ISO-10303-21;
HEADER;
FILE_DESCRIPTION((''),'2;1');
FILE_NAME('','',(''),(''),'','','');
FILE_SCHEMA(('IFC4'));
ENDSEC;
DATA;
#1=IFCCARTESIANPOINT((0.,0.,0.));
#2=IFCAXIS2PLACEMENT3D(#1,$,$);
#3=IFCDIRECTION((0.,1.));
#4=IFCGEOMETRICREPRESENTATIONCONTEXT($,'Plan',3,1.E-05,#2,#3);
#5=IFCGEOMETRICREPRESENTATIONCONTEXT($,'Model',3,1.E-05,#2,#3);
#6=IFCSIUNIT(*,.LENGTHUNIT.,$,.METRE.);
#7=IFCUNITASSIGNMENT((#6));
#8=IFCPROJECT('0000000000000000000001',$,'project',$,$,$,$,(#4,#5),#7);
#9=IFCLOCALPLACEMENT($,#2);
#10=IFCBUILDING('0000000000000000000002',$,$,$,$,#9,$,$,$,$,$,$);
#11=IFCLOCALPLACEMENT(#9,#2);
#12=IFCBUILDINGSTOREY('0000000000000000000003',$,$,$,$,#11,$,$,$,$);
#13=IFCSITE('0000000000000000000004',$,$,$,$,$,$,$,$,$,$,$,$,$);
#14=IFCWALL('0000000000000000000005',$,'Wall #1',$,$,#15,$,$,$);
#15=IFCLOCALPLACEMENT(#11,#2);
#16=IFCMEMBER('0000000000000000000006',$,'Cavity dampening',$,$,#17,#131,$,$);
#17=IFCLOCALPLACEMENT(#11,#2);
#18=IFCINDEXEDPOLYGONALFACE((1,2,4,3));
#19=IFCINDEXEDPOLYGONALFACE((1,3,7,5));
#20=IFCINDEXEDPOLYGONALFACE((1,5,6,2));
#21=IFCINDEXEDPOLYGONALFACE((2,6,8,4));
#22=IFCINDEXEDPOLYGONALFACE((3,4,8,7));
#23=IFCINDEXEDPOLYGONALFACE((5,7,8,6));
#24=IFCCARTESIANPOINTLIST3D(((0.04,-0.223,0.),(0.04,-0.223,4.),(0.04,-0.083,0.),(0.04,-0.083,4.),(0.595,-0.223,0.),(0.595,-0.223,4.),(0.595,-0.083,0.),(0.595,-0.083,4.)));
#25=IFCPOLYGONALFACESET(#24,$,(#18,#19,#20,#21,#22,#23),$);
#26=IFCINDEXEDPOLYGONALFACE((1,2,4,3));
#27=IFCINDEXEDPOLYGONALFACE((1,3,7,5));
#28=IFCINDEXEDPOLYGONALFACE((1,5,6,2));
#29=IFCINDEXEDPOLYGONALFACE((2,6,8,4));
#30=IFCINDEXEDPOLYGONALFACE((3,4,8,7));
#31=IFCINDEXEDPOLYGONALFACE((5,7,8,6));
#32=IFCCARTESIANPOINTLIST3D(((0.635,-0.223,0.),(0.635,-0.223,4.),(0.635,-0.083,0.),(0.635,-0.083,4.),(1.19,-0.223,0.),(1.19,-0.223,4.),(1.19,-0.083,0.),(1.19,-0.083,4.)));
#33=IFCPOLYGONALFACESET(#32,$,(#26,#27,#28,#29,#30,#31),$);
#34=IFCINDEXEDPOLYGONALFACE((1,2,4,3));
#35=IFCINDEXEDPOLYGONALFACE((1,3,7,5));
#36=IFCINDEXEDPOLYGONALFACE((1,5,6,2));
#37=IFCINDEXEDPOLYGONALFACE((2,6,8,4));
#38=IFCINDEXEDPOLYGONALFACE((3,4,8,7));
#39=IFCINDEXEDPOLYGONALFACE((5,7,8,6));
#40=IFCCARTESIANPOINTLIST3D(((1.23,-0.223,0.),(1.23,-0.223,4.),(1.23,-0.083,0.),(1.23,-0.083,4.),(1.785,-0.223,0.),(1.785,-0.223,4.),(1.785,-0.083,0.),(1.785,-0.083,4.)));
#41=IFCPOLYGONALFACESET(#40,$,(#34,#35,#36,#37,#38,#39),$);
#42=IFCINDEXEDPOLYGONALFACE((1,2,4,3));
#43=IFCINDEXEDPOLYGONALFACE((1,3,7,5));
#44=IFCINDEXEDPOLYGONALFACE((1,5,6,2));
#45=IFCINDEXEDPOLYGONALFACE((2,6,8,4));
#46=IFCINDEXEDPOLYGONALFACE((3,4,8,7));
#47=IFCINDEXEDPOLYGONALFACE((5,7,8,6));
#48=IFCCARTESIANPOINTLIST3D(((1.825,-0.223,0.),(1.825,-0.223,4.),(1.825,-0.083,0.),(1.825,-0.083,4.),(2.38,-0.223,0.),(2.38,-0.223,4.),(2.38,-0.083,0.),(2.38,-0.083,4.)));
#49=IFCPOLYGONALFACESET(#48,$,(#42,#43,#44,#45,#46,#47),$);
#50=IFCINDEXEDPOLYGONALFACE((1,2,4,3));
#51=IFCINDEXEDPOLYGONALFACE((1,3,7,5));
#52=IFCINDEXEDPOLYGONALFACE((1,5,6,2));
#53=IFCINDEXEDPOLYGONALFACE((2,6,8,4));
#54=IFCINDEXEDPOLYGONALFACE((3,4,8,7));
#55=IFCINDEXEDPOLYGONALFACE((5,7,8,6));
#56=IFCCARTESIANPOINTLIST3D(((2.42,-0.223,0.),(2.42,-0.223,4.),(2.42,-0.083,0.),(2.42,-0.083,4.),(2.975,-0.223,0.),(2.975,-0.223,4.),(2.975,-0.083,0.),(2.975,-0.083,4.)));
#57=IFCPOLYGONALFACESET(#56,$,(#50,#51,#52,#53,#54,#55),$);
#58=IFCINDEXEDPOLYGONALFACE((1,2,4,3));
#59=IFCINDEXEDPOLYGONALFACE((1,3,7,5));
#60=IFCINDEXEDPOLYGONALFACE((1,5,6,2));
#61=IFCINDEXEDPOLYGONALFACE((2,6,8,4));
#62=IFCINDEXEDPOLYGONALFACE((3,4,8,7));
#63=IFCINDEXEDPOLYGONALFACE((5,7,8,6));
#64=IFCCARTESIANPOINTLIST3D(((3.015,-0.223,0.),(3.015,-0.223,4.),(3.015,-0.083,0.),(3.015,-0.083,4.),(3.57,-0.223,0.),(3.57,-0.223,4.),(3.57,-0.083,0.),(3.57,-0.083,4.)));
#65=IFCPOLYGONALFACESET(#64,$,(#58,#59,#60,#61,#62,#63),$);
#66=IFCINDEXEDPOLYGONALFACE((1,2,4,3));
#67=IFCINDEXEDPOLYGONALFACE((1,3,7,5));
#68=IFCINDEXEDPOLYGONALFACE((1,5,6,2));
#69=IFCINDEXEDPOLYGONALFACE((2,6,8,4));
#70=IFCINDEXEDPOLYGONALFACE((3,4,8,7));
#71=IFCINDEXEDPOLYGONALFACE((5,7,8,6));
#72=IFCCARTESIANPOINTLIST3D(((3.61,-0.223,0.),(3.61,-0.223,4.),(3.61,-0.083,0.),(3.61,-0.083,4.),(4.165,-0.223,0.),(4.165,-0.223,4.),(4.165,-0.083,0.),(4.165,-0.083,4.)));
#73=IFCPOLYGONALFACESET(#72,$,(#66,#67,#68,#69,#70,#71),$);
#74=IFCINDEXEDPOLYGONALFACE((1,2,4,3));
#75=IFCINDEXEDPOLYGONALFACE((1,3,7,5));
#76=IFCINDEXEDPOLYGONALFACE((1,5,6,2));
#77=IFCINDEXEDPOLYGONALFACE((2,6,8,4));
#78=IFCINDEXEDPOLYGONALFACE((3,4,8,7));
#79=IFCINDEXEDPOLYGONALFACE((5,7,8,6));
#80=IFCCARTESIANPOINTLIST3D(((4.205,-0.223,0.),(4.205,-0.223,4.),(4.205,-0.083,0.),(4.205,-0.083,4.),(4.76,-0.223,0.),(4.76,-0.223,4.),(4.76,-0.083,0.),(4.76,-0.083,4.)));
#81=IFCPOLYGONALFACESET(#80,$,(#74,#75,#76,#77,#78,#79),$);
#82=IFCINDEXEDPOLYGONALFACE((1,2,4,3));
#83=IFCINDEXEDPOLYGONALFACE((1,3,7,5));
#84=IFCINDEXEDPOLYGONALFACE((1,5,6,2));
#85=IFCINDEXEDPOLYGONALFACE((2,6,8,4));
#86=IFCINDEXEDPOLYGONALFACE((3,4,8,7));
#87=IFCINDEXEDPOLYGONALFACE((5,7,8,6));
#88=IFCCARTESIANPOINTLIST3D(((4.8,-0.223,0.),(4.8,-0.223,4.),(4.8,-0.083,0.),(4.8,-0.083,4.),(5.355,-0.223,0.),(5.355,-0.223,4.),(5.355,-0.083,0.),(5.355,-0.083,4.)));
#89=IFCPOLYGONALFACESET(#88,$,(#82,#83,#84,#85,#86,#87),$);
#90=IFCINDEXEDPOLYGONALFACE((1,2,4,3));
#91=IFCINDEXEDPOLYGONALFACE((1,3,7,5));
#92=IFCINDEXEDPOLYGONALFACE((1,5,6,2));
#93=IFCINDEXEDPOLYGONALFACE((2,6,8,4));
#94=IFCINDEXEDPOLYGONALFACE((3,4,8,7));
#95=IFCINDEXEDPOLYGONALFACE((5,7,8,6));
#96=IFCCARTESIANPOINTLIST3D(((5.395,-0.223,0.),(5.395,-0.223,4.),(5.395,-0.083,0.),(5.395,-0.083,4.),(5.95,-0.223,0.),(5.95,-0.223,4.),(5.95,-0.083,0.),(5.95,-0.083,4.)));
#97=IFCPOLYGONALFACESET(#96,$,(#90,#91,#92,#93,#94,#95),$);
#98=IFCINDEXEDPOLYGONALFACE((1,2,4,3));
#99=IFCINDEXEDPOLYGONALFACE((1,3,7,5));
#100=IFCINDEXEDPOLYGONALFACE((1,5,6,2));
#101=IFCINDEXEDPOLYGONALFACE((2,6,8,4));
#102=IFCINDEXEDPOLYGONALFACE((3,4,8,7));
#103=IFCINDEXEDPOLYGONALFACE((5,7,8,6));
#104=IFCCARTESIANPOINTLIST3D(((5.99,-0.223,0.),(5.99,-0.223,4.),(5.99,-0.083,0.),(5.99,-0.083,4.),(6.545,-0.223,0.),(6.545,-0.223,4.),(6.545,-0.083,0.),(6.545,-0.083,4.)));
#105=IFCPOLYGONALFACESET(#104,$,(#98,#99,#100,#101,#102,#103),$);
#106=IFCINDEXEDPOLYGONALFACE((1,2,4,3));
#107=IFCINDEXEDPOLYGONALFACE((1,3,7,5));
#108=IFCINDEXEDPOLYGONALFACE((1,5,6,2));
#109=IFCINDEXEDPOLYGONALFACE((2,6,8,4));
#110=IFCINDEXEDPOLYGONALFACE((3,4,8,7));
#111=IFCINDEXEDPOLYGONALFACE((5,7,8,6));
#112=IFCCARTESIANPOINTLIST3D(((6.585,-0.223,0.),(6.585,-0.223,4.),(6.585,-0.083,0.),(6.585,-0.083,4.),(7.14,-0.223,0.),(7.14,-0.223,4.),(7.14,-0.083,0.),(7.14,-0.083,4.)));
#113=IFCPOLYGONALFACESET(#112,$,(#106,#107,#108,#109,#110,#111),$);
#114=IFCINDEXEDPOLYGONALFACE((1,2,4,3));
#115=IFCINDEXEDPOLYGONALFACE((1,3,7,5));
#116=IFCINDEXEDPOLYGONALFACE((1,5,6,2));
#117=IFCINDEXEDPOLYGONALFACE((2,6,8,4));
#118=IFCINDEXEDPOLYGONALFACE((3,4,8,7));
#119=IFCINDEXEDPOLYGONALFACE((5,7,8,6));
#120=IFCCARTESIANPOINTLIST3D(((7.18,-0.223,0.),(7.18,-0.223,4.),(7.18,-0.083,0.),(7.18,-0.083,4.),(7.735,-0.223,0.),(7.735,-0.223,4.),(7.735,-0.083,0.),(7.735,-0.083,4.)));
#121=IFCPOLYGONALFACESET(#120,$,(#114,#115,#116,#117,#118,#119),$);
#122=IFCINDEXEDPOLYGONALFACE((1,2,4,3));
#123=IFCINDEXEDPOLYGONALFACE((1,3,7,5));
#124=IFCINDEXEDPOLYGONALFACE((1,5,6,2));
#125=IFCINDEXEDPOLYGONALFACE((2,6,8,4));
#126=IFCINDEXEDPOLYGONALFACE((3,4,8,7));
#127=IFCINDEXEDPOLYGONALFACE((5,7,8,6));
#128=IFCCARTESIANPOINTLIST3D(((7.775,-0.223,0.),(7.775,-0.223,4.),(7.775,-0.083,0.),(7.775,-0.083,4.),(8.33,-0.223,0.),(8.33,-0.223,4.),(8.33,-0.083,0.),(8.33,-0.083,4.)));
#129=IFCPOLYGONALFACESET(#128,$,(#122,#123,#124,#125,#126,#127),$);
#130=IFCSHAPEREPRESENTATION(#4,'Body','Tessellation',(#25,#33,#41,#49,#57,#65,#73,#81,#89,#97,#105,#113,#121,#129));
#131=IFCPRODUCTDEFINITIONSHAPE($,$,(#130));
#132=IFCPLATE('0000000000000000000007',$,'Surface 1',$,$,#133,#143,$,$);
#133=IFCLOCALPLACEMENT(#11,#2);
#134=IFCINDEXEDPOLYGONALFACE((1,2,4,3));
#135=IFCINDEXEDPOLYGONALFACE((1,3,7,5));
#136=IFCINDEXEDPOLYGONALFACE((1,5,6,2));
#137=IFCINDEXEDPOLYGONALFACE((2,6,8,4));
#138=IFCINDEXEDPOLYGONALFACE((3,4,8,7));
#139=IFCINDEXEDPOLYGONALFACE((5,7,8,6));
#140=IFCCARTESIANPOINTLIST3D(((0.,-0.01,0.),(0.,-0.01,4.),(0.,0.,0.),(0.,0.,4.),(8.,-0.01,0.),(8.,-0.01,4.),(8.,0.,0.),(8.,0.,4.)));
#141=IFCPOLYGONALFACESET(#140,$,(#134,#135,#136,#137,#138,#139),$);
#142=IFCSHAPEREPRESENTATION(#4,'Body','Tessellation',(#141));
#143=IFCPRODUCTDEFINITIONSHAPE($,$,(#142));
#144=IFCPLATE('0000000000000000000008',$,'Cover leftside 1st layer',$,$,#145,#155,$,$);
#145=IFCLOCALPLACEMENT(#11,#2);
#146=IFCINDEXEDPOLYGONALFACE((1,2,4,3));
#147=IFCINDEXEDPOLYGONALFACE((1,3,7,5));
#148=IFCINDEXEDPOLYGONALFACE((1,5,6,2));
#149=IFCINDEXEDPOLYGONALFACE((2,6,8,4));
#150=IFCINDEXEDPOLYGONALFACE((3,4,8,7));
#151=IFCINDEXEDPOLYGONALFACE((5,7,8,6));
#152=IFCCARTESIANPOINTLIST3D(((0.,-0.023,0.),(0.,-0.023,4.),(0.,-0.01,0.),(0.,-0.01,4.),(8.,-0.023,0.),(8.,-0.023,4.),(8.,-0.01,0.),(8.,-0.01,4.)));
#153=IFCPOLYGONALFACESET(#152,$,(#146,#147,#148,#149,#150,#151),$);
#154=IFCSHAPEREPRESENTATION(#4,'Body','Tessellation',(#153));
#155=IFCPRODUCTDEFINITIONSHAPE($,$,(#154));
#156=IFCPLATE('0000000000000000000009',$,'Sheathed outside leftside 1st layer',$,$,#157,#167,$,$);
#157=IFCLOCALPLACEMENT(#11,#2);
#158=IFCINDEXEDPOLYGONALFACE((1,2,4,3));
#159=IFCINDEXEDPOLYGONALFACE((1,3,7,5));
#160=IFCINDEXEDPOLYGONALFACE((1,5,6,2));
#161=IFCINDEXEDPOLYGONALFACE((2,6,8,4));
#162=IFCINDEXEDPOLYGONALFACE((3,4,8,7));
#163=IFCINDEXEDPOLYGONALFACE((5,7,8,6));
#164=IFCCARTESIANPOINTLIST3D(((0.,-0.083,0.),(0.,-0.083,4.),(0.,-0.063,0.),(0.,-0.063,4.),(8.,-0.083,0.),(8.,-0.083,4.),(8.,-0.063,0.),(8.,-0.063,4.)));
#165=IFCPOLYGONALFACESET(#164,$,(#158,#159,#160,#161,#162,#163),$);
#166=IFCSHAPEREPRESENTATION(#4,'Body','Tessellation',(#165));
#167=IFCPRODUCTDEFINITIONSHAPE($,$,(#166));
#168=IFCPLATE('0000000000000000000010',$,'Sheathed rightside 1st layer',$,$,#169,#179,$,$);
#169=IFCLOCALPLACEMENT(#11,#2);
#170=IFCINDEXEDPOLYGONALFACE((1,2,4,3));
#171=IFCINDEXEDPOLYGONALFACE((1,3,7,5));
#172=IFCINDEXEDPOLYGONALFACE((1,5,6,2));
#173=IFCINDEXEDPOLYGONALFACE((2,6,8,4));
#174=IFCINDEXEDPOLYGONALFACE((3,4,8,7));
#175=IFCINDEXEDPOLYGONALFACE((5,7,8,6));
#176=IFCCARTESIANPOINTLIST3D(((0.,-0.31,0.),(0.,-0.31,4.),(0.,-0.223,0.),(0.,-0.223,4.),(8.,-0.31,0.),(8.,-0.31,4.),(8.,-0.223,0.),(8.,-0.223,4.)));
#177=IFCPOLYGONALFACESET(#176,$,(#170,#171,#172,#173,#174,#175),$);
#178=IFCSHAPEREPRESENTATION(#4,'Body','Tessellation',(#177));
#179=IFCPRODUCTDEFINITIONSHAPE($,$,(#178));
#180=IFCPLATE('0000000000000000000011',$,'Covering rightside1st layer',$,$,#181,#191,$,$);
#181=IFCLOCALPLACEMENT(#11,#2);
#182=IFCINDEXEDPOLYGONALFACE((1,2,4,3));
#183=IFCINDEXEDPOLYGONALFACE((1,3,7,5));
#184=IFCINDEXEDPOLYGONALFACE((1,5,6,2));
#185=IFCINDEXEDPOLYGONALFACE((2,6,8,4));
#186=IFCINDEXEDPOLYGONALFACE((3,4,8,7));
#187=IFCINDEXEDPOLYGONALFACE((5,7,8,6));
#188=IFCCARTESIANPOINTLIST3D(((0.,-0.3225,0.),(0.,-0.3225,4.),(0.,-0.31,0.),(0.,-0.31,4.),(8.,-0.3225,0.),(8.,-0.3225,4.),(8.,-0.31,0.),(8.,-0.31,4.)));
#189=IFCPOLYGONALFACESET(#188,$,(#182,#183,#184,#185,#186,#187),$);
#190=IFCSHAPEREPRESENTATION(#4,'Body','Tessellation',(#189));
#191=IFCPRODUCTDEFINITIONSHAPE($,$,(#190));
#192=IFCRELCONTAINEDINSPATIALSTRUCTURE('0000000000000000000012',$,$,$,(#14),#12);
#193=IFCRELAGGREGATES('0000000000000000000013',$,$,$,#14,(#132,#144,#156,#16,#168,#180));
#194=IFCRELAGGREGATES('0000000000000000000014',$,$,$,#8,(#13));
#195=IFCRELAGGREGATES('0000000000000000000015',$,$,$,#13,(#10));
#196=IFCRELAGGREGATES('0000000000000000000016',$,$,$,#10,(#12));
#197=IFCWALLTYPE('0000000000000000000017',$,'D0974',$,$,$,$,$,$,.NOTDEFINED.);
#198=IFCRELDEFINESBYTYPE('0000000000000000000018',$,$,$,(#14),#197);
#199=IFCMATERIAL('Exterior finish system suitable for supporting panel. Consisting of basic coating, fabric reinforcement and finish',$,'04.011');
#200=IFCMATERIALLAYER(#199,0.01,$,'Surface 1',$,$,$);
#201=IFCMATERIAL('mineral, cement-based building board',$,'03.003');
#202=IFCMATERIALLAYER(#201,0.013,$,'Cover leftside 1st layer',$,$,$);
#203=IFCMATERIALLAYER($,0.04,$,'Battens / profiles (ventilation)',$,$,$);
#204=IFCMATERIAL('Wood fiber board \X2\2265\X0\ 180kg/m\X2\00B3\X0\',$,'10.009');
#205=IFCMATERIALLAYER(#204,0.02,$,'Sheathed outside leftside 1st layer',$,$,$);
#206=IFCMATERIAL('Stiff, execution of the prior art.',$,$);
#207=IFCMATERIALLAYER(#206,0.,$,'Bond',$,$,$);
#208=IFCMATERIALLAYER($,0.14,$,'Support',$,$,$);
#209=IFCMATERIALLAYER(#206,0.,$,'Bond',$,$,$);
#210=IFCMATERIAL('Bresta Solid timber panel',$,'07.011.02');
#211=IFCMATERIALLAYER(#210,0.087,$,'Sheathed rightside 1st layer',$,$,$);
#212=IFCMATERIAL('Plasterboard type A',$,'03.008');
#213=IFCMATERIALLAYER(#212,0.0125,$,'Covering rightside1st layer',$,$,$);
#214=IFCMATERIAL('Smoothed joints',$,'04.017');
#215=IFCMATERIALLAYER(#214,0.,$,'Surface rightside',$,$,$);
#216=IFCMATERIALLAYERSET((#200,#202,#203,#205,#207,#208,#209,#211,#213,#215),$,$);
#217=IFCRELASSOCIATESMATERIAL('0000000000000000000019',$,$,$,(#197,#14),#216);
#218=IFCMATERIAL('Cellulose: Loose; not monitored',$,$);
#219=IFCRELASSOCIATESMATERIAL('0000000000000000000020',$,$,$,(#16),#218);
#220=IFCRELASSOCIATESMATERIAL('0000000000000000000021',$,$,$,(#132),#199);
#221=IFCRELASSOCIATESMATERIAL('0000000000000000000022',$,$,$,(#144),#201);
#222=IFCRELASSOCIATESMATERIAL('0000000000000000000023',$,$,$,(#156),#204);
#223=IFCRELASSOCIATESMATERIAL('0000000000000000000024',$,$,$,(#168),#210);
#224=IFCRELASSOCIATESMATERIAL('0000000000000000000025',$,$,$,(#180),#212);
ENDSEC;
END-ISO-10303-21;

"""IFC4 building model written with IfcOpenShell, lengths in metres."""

from ifc_helpers import new_model, si_unit, direction, frame, frame_2d, origin, origin_with_axes, place, context, project, spatial, rectangle, extrude, material, layer, layer_set, type_object, element, aggregate, save


model = new_model("IFC4")

# Units and contexts
plan_context = context("Plan", 3, precision=1e-05, world=origin(), true_north=direction((0.0, 1.0)))
model_context = context("Model", 3, precision=1e-05, world=origin(), true_north=direction((0.0, 1.0)))
ifc_project = project(units=[si_unit("LENGTHUNIT", "METRE")], contexts=[plan_context, model_context])

# Site, building, storey
site = spatial("IfcSite", under=ifc_project)
building_placement = place(None, origin())
building = spatial("IfcBuilding", under=site, at=building_placement)
storey_placement = place(building_placement, origin())
storey = spatial("IfcBuildingStorey", under=building, at=storey_placement)

# Wall, member, plates
ifc_material_1 = material(Name="Exterior finish system suitable for supporting panel. Consisting of basic coating, fabric reinforcement and finish", Category="04.011")
ifc_layer_1 = layer(ifc_material_1, 0.01, Name="Surface 1")
ifc_material_2 = material(Name="mineral, cement-based building board", Category="03.003")
ifc_layer_2 = layer(ifc_material_2, 0.013, Name="Cover leftside 1st layer")
ifc_layer_3 = layer(None, 0.04, Name="Battens / profiles (ventilation)")
ifc_material_3 = material(Name="Wood fiber board ≥ 180kg/m³", Category="10.009")
ifc_layer_4 = layer(ifc_material_3, 0.02, Name="Sheathed outside leftside 1st layer")
ifc_material_4 = material(Name="Stiff, execution of the prior art.")
ifc_layer_5 = layer(ifc_material_4, 0.0, Name="Bond")
ifc_layer_6 = layer(None, 0.14, Name="Support")
ifc_layer_7 = layer(ifc_material_4, 0.0, Name="Bond")
ifc_material_5 = material(Name="Bresta Solid timber panel", Category="07.011.02")
ifc_layer_8 = layer(ifc_material_5, 0.087, Name="Sheathed rightside 1st layer")
ifc_material_6 = material(Name="Plasterboard type A", Category="03.008")
ifc_layer_9 = layer(ifc_material_6, 0.0125, Name="Covering rightside1st layer")
ifc_material_7 = material(Name="Smoothed joints", Category="04.017")
ifc_layer_10 = layer(ifc_material_7, 0.0, Name="Surface rightside")
ifc_layer_set = layer_set([ifc_layer_1, ifc_layer_2, ifc_layer_3, ifc_layer_4, ifc_layer_5, ifc_layer_6, ifc_layer_7, ifc_layer_8, ifc_layer_9, ifc_layer_10])
wall_type = type_object("IfcWallType", Name="D0974", PredefinedType="NOTDEFINED", material=ifc_layer_set)
wall_placement = place(None, frame((0.0, 0.0, 0.0), z_axis=(0.0, -1.0, 0.0), x_axis=(1.0, 0.0, 0.0)))
wall = element("IfcWall", 1, at=wall_placement, inside=storey, type_object=wall_type, material=ifc_layer_set, Name="Wall #1")
ifc_material_8 = material(Name="Cellulose: Loose; not monitored")
member_1_placement = place(wall_placement, origin())
member_1 = element("IfcMember", 2, at=member_1_placement, material=ifc_material_8, Name="Cavity dampening", context=plan_context, shape_type="SweptSolid", body=[
    extrude(rectangle(XDim=0.555, YDim=0.14, at=frame_2d((0.2775, 0.07), x_axis=(1.0, 0.0))), frame((0.04, 4.0, 0.083), z_axis=(0.0, -1.0, 0.0), x_axis=(1.0, 0.0, 0.0)), (0.0, 0.0, 1.0), 4.0),
    extrude(rectangle(XDim=0.555, YDim=0.14, at=frame_2d((0.2775, 0.07), x_axis=(1.0, 0.0))), frame((0.635, 4.0, 0.083), z_axis=(0.0, -1.0, 0.0), x_axis=(1.0, 0.0, 0.0)), (0.0, 0.0, 1.0), 4.0),
    extrude(rectangle(XDim=0.555, YDim=0.14, at=frame_2d((0.2775, 0.07), x_axis=(1.0, 0.0))), frame((1.23, 4.0, 0.083), z_axis=(0.0, -1.0, 0.0), x_axis=(1.0, 0.0, 0.0)), (0.0, 0.0, 1.0), 4.0),
    extrude(rectangle(XDim=0.555, YDim=0.14, at=frame_2d((0.2775, 0.07), x_axis=(1.0, 0.0))), frame((1.825, 4.0, 0.083), z_axis=(0.0, -1.0, 0.0), x_axis=(1.0, 0.0, 0.0)), (0.0, 0.0, 1.0), 4.0),
    extrude(rectangle(XDim=0.555, YDim=0.14, at=frame_2d((0.2775, 0.07), x_axis=(1.0, 0.0))), frame((2.42, 4.0, 0.083), z_axis=(0.0, -1.0, 0.0), x_axis=(1.0, 0.0, 0.0)), (0.0, 0.0, 1.0), 4.0),
    extrude(rectangle(XDim=0.555, YDim=0.14, at=frame_2d((0.2775, 0.07), x_axis=(1.0, 0.0))), frame((3.015, 4.0, 0.083), z_axis=(0.0, -1.0, 0.0), x_axis=(1.0, 0.0, 0.0)), (0.0, 0.0, 1.0), 4.0),
    extrude(rectangle(XDim=0.555, YDim=0.14, at=frame_2d((0.2775, 0.07), x_axis=(1.0, 0.0))), frame((3.61, 4.0, 0.083), z_axis=(0.0, -1.0, 0.0), x_axis=(1.0, 0.0, 0.0)), (0.0, 0.0, 1.0), 4.0),
    extrude(rectangle(XDim=0.555, YDim=0.14, at=frame_2d((0.2775, 0.07), x_axis=(1.0, 0.0))), frame((4.205, 4.0, 0.083), z_axis=(0.0, -1.0, 0.0), x_axis=(1.0, 0.0, 0.0)), (0.0, 0.0, 1.0), 4.0),
    extrude(rectangle(XDim=0.555, YDim=0.14, at=frame_2d((0.2775, 0.07), x_axis=(1.0, 0.0))), frame((4.8, 4.0, 0.083), z_axis=(0.0, -1.0, 0.0), x_axis=(1.0, 0.0, 0.0)), (0.0, 0.0, 1.0), 4.0),
    extrude(rectangle(XDim=0.555, YDim=0.14, at=frame_2d((0.2775, 0.07), x_axis=(1.0, 0.0))), frame((5.395, 4.0, 0.083), z_axis=(0.0, -1.0, 0.0), x_axis=(1.0, 0.0, 0.0)), (0.0, 0.0, 1.0), 4.0),
    extrude(rectangle(XDim=0.555, YDim=0.14, at=frame_2d((0.2775, 0.07), x_axis=(1.0, 0.0))), frame((5.99, 4.0, 0.083), z_axis=(0.0, -1.0, 0.0), x_axis=(1.0, 0.0, 0.0)), (0.0, 0.0, 1.0), 4.0),
    extrude(rectangle(XDim=0.555, YDim=0.14, at=frame_2d((0.2775, 0.07), x_axis=(1.0, 0.0))), frame((6.585, 4.0, 0.083), z_axis=(0.0, -1.0, 0.0), x_axis=(1.0, 0.0, 0.0)), (0.0, 0.0, 1.0), 4.0),
    extrude(rectangle(XDim=0.555, YDim=0.14, at=frame_2d((0.2775, 0.07), x_axis=(1.0, 0.0))), frame((7.18, 4.0, 0.083), z_axis=(0.0, -1.0, 0.0), x_axis=(1.0, 0.0, 0.0)), (0.0, 0.0, 1.0), 4.0),
    extrude(rectangle(XDim=0.555, YDim=0.14, at=frame_2d((0.2775, 0.07), x_axis=(1.0, 0.0))), frame((7.775, 4.0, 0.083), z_axis=(0.0, -1.0, 0.0), x_axis=(1.0, 0.0, 0.0)), (0.0, 0.0, 1.0), 4.0),
])
plate_1_placement = place(wall_placement, origin())
plate_1 = element("IfcPlate", 3, at=plate_1_placement, material=ifc_material_1, Name="Surface 1", context=plan_context, shape_type="SweptSolid", body=[
    extrude(rectangle(XDim=8.0, YDim=4.0, at=frame_2d((4.0, 2.0), x_axis=(1.0, 0.0))), origin_with_axes(), (0.0, 0.0, 1.0), 0.01),
])
plate_2_placement = place(wall_placement, origin())
plate_2 = element("IfcPlate", 4, at=plate_2_placement, material=ifc_material_2, Name="Cover leftside 1st layer", context=plan_context, shape_type="SweptSolid", body=[
    extrude(rectangle(XDim=8.0, YDim=4.0, at=frame_2d((4.0, 2.0), x_axis=(1.0, 0.0))), frame((0.0, 0.0, 0.01), z_axis=(0.0, 0.0, 1.0), x_axis=(1.0, 0.0, 0.0)), (0.0, 0.0, 1.0), 0.013),
])
plate_3_placement = place(wall_placement, origin())
plate_3 = element("IfcPlate", 5, at=plate_3_placement, material=ifc_material_3, Name="Sheathed outside leftside 1st layer", context=plan_context, shape_type="SweptSolid", body=[
    extrude(rectangle(XDim=8.0, YDim=4.0, at=frame_2d((4.0, 2.0), x_axis=(1.0, 0.0))), frame((0.0, 0.0, 0.063), z_axis=(0.0, 0.0, 1.0), x_axis=(1.0, 0.0, 0.0)), (0.0, 0.0, 1.0), 0.02),
])
plate_4_placement = place(wall_placement, origin())
plate_4 = element("IfcPlate", 6, at=plate_4_placement, material=ifc_material_5, Name="Sheathed rightside 1st layer", context=plan_context, shape_type="SweptSolid", body=[
    extrude(rectangle(XDim=8.0, YDim=4.0, at=frame_2d((4.0, 2.0), x_axis=(1.0, 0.0))), frame((0.0, 0.0, 0.223), z_axis=(0.0, 0.0, 1.0), x_axis=(1.0, 0.0, 0.0)), (0.0, 0.0, 1.0), 0.087),
])
plate_5_placement = place(wall_placement, origin())
plate_5 = element("IfcPlate", 7, at=plate_5_placement, material=ifc_material_6, Name="Covering rightside1st layer", context=plan_context, shape_type="SweptSolid", body=[
    extrude(rectangle(XDim=8.0, YDim=4.0, at=frame_2d((4.0, 2.0), x_axis=(1.0, 0.0))), frame((0.0, 0.0, 0.31), z_axis=(0.0, 0.0, 1.0), x_axis=(1.0, 0.0, 0.0)), (0.0, 0.0, 1.0), 0.0125),
])
aggregate(wall, [plate_1, plate_2, plate_3, member_1, plate_4, plate_5])

save(model, "model.ifc")
